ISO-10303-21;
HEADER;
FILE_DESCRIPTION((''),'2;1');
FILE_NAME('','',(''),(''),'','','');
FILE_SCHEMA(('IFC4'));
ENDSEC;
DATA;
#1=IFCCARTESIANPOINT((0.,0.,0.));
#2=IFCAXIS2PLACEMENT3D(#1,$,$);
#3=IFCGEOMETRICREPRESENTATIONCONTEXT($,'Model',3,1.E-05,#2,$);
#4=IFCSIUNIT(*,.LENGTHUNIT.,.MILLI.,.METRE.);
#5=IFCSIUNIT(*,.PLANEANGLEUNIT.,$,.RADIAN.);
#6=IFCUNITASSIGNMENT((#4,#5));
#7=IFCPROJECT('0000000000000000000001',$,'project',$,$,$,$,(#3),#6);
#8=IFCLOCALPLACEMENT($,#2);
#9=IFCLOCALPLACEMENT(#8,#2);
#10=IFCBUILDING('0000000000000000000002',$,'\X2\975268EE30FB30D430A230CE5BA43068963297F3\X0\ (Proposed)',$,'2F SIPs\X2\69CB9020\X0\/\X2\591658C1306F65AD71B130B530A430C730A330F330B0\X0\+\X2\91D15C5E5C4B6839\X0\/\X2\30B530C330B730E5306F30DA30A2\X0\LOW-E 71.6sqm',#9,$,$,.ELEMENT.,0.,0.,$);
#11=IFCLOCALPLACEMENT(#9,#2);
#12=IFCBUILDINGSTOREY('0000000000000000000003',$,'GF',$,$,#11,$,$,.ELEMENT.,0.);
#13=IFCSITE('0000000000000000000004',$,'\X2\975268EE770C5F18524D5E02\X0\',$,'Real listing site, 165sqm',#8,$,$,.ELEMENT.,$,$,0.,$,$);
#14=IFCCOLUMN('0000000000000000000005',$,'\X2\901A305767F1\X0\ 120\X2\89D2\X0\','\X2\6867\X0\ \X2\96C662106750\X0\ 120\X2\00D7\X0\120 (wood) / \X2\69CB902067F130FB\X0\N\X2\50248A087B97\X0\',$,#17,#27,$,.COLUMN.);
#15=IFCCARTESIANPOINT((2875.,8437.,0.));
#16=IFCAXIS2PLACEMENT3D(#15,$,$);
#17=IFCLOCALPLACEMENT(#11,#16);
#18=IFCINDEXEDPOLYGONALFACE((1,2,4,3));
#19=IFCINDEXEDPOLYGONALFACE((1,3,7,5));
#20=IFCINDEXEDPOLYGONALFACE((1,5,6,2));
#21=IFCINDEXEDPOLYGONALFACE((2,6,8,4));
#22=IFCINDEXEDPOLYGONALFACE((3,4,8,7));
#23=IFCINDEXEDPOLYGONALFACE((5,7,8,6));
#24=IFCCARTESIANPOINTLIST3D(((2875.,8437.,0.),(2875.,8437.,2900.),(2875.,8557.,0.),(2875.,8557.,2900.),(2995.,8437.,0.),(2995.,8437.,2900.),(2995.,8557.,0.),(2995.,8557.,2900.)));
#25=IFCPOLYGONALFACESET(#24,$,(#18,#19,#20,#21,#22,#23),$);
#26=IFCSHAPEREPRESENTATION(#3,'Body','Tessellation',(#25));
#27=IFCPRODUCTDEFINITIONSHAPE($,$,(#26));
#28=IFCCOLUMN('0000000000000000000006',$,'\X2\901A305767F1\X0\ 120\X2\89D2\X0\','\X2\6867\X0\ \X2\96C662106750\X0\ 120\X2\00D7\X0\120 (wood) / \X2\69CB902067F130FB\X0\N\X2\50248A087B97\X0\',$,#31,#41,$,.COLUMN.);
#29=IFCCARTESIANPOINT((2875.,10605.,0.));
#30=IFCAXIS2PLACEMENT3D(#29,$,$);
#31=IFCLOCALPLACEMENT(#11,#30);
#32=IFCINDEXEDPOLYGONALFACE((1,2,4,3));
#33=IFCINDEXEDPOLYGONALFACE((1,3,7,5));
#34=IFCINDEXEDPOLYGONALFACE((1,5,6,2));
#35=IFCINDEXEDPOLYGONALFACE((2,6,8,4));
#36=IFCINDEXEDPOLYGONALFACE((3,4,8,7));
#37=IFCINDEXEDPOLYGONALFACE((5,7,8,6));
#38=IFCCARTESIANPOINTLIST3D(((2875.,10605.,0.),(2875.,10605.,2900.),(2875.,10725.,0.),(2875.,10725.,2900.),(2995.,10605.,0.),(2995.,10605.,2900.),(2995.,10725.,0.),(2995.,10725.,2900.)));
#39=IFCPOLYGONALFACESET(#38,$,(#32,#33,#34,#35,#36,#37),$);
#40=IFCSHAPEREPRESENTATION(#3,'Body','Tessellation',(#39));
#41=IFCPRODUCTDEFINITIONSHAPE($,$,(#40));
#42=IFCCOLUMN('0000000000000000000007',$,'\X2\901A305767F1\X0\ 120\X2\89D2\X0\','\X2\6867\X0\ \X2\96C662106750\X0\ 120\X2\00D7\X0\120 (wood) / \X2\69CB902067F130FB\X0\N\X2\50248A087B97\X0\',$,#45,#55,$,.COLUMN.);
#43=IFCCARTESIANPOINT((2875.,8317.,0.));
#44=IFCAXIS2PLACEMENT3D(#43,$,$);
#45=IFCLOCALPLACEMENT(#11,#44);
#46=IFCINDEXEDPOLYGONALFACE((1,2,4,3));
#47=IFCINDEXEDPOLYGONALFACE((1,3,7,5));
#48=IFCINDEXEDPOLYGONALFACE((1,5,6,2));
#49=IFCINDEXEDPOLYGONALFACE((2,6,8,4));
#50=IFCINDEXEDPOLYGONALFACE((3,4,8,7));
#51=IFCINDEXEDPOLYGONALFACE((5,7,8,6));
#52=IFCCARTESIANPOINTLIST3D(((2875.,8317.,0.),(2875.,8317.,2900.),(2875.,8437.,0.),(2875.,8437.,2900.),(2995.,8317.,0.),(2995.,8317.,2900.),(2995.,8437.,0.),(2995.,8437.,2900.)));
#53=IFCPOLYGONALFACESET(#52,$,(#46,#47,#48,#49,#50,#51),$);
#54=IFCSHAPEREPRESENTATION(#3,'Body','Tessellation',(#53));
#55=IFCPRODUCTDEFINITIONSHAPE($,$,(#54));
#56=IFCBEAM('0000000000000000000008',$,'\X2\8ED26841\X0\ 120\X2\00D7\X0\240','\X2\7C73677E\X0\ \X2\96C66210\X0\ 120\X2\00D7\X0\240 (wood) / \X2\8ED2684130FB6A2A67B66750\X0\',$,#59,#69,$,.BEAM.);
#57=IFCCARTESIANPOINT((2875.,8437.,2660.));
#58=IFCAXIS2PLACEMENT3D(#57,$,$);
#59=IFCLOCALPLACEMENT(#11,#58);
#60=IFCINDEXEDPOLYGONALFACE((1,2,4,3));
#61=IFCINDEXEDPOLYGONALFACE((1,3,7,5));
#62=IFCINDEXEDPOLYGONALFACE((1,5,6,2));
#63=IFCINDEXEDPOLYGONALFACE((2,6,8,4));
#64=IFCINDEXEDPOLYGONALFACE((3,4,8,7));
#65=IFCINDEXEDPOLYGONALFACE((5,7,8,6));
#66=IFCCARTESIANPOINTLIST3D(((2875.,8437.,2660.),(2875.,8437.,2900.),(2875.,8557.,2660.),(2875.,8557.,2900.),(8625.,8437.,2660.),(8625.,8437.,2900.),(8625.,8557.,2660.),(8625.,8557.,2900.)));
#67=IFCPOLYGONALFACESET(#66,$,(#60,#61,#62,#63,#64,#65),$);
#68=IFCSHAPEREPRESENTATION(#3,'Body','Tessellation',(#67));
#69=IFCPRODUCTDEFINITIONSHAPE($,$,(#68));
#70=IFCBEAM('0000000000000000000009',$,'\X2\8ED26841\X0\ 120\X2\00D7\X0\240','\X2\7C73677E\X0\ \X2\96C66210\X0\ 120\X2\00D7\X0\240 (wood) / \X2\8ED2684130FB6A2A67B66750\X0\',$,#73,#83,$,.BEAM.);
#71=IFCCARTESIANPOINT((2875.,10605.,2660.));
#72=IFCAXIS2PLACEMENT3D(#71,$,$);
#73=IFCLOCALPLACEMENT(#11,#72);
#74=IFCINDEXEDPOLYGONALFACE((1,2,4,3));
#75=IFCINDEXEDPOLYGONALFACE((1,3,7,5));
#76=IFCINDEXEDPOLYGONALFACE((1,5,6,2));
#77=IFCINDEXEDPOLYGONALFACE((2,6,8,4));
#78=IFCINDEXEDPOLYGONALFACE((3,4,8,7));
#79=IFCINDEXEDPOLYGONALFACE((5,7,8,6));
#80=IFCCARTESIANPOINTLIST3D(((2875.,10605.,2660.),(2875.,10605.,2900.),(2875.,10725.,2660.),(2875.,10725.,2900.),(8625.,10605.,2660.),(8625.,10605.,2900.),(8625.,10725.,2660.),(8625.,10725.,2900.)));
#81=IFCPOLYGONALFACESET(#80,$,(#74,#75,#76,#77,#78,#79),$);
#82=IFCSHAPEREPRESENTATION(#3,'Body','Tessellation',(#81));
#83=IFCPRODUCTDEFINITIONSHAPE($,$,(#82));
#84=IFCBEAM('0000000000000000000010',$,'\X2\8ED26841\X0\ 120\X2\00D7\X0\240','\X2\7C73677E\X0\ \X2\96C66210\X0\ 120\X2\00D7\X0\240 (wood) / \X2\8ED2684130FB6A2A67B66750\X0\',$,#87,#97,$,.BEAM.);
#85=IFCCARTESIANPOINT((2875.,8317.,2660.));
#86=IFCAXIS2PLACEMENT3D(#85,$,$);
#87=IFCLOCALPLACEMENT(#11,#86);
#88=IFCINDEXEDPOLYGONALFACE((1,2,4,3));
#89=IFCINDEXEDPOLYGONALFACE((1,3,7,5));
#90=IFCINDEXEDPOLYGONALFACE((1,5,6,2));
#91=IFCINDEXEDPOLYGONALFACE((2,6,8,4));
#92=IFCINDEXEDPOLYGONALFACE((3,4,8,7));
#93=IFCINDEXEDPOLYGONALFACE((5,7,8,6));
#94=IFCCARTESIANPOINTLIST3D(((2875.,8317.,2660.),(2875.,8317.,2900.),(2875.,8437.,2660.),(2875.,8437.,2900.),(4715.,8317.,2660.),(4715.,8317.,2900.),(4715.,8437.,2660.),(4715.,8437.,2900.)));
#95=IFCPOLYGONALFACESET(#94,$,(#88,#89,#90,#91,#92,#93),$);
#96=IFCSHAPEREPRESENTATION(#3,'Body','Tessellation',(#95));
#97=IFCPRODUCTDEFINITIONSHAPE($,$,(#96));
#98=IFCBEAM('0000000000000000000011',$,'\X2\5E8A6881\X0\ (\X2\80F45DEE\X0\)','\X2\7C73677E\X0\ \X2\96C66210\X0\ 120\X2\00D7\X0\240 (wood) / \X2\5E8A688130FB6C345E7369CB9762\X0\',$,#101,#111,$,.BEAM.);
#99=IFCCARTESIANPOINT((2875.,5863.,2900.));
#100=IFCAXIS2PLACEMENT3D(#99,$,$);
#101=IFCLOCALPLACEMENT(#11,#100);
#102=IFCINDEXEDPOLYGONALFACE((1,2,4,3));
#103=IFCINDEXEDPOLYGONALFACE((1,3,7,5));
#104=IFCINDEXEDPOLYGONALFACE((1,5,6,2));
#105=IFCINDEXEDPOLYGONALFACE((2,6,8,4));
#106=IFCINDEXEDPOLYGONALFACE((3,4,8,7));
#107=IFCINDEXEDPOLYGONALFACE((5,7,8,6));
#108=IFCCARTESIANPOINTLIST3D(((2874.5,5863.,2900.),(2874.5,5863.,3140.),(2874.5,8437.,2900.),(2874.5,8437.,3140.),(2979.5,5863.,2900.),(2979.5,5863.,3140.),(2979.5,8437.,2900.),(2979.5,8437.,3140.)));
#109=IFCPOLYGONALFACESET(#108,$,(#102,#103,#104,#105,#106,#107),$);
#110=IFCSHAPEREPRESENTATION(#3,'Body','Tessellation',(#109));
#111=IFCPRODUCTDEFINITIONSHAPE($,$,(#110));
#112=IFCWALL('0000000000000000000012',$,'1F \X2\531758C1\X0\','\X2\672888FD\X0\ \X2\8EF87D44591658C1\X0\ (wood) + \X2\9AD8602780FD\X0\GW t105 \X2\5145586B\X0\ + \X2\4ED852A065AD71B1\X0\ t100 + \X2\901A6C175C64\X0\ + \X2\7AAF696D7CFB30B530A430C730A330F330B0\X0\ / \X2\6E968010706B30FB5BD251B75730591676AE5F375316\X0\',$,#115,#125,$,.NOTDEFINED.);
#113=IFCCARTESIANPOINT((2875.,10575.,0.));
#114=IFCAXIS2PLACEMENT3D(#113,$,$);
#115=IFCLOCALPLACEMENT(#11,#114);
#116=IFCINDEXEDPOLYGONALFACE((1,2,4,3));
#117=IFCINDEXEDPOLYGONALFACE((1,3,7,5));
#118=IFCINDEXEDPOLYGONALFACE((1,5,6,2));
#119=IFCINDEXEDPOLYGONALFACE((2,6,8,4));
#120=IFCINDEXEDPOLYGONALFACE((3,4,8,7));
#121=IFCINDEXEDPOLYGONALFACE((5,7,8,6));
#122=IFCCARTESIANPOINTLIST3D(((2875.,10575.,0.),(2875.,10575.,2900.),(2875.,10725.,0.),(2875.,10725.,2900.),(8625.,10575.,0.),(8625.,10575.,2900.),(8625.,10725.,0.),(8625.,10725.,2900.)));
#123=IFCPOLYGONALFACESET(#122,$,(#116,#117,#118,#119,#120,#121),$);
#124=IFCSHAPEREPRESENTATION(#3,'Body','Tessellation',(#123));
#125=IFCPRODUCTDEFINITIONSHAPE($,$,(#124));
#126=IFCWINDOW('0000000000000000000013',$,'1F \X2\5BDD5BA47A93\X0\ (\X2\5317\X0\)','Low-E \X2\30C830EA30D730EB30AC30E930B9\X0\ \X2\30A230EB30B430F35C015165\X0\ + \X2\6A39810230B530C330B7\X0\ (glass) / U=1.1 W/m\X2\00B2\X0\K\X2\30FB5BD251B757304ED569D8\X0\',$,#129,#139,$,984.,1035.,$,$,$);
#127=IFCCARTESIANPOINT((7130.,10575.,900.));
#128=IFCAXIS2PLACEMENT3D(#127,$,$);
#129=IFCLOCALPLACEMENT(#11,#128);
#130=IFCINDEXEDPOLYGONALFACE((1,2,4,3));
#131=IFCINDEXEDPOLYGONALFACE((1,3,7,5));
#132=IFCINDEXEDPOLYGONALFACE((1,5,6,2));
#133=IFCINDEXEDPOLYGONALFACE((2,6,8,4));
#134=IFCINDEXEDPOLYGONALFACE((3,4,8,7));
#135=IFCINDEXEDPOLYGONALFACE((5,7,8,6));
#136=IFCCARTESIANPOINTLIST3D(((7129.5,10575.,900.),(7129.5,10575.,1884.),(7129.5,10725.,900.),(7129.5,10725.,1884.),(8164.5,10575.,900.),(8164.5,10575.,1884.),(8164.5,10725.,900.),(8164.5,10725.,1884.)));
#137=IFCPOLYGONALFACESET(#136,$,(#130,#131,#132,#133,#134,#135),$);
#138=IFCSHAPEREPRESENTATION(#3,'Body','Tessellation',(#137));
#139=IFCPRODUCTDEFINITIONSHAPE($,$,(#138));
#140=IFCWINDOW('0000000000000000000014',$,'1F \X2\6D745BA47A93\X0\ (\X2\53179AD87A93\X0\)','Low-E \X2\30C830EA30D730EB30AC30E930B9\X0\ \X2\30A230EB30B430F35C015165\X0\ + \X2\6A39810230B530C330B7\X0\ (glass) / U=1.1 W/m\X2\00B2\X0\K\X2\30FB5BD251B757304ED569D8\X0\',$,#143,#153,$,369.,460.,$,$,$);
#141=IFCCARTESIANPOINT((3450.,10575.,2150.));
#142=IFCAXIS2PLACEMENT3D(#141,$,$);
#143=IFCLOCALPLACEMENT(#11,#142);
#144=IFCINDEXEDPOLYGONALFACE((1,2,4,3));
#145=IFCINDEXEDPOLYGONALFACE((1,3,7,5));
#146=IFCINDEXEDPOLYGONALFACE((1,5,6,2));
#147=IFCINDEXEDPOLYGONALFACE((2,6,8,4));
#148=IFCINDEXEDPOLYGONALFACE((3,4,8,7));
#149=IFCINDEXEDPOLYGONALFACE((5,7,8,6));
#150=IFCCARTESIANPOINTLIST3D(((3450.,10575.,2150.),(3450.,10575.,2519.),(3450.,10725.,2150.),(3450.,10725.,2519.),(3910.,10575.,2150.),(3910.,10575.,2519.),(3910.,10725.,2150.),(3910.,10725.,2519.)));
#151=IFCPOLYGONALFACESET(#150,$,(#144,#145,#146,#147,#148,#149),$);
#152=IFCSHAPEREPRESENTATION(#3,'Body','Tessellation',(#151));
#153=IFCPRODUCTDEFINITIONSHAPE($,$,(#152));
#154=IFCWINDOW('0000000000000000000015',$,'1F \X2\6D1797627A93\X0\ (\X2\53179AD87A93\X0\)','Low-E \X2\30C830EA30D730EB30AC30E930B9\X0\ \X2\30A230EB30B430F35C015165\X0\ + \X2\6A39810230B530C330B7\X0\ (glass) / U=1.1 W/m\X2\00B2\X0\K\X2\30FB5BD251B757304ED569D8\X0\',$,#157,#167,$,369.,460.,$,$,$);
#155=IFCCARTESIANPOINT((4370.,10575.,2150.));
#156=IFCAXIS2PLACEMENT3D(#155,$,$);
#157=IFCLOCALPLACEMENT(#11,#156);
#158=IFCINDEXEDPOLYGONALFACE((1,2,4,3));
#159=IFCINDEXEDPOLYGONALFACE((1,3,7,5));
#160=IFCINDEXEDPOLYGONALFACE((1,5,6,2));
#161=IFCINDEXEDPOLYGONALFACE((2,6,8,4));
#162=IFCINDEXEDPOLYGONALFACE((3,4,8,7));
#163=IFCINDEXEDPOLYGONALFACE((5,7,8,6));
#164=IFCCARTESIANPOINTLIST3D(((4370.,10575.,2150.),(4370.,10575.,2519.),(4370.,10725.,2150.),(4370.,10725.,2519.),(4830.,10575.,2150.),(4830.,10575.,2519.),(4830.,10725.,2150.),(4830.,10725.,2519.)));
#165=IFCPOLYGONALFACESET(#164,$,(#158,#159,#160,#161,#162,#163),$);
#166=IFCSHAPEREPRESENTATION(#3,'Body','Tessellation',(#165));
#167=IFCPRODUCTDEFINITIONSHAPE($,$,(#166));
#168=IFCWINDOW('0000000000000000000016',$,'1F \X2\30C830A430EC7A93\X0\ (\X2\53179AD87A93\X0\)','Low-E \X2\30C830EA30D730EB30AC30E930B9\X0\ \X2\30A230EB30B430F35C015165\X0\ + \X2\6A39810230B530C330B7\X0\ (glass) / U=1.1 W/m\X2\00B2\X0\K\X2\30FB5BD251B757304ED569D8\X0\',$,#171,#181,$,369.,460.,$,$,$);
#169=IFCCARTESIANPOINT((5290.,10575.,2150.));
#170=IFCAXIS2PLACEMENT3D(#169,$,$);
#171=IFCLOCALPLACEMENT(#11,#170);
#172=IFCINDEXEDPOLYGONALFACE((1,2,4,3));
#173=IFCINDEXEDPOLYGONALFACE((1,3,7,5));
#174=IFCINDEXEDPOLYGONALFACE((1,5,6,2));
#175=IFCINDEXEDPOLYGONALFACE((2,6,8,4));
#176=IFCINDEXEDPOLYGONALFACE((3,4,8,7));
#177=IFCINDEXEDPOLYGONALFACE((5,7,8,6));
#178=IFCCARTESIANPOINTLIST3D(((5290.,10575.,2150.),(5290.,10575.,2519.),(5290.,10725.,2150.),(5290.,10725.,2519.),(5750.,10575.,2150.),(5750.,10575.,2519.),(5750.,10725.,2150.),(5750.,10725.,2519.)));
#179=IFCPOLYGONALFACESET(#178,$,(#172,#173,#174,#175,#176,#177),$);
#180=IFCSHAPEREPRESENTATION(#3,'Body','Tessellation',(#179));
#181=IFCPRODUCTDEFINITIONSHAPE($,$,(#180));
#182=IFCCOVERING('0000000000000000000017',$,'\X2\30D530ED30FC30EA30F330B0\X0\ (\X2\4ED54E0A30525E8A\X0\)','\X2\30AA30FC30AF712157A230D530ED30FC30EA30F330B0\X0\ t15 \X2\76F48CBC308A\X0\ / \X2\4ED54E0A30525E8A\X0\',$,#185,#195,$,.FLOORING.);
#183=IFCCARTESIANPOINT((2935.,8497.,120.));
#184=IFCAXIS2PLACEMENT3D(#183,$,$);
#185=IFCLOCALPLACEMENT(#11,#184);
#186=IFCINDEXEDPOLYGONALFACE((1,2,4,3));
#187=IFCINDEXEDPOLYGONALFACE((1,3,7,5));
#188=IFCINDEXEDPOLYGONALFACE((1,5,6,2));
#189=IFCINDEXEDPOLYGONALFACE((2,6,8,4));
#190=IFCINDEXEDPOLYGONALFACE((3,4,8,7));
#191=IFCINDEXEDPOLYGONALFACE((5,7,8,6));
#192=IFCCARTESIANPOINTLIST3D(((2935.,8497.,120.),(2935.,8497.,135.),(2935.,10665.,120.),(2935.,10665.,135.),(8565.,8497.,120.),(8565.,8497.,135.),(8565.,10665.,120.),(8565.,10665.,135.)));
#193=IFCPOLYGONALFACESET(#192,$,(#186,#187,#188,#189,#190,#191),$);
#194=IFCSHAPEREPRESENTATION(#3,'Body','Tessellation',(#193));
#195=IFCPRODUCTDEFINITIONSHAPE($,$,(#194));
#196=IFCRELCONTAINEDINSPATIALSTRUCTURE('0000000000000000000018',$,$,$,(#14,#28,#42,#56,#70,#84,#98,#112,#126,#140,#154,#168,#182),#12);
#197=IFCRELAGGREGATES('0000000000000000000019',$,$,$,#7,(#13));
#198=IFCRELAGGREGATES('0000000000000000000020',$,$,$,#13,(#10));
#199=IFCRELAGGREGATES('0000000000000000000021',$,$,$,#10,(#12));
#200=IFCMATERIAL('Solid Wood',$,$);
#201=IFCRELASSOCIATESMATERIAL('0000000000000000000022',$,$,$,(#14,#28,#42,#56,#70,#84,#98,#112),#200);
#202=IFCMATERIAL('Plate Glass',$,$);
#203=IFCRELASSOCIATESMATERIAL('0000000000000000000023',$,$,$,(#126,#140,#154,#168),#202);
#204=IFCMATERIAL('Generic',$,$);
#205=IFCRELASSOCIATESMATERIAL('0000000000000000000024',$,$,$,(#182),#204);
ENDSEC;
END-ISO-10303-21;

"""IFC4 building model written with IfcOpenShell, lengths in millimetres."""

from ifc_helpers import new_model, si_unit, frame, frame_2d, origin, place, context, project, spatial, rectangle, extrude, material, element, fill, save


model = new_model("IFC4")

# Units and contexts
model_context = context("Model", 3, precision=1e-05, world=origin())
ifc_project = project(units=[si_unit("LENGTHUNIT", "METRE", prefix="MILLI"), si_unit("PLANEANGLEUNIT", "RADIAN")], contexts=[model_context])

# Site, building, storey
site_placement = place(None, origin())
site = spatial("IfcSite", under=ifc_project, at=site_placement, Name="青森県弘前市", ObjectType="Real listing site, 165sqm", CompositionType="ELEMENT", RefElevation=0.0)
building_placement = place(site_placement, origin())
building = spatial("IfcBuilding", under=site, at=building_placement, Name="青森・ピアノ室と防音 (Proposed)", ObjectType="2F SIPs構造/外壁は断熱サイディング+金属屋根/サッシュはペアLOW-E 71.6sqm", CompositionType="ELEMENT", ElevationOfRefHeight=0.0, ElevationOfTerrain=0.0)
storey_placement = place(building_placement, origin())
storey = spatial("IfcBuildingStorey", under=building, at=storey_placement, Name="GF", CompositionType="ELEMENT", Elevation=0.0)

# Columns
ifc_material_1 = material(Name="Solid Wood")
column_1_placement = place(storey_placement, frame((2875.0, 8437.0, 0.0)))
element("IfcColumn", 1, at=column_1_placement, inside=storey, material=ifc_material_1, Name="通し柱 120角", Description="桧 集成材 120×120 (wood) / 構造柱・N値計算", PredefinedType="COLUMN", context=model_context, shape_type="SweptSolid", body=[
    extrude(rectangle(XDim=120.0, YDim=120.0, at=frame_2d((60.0, 60.0))), frame((2875.0, 8437.0, 0.0)), (0.0, 0.0, 1.0), 2900.0),
])
column_2_placement = place(storey_placement, frame((2875.0, 10605.0, 0.0)))
element("IfcColumn", 2, at=column_2_placement, inside=storey, material=ifc_material_1, Name="通し柱 120角", Description="桧 集成材 120×120 (wood) / 構造柱・N値計算", PredefinedType="COLUMN", context=model_context, shape_type="SweptSolid", body=[
    extrude(rectangle(XDim=120.0, YDim=120.0, at=frame_2d((60.0, 60.0))), frame((2875.0, 10605.0, 0.0)), (0.0, 0.0, 1.0), 2900.0),
])
column_3_placement = place(storey_placement, frame((2875.0, 8317.0, 0.0)))
element("IfcColumn", 3, at=column_3_placement, inside=storey, material=ifc_material_1, Name="通し柱 120角", Description="桧 集成材 120×120 (wood) / 構造柱・N値計算", PredefinedType="COLUMN", context=model_context, shape_type="SweptSolid", body=[
    extrude(rectangle(XDim=120.0, YDim=120.0, at=frame_2d((60.0, 60.0))), frame((2875.0, 8317.0, 0.0)), (0.0, 0.0, 1.0), 2900.0),
])

# Beams
beam_1_placement = place(storey_placement, frame((2875.0, 8437.0, 2660.0)))
element("IfcBeam", 4, at=beam_1_placement, inside=storey, material=ifc_material_1, Name="軒桁 120×240", Description="米松 集成 120×240 (wood) / 軒桁・横架材", PredefinedType="BEAM", context=model_context, shape_type="SweptSolid", body=[
    extrude(rectangle(XDim=5750.0, YDim=120.0, at=frame_2d((2875.0, 60.0))), frame((2875.0, 8437.0, 2660.0)), (0.0, 0.0, 1.0), 240.0),
])
beam_2_placement = place(storey_placement, frame((2875.0, 10605.0, 2660.0)))
element("IfcBeam", 5, at=beam_2_placement, inside=storey, material=ifc_material_1, Name="軒桁 120×240", Description="米松 集成 120×240 (wood) / 軒桁・横架材", PredefinedType="BEAM", context=model_context, shape_type="SweptSolid", body=[
    extrude(rectangle(XDim=5750.0, YDim=120.0, at=frame_2d((2875.0, 60.0))), frame((2875.0, 10605.0, 2660.0)), (0.0, 0.0, 1.0), 240.0),
])
beam_3_placement = place(storey_placement, frame((2875.0, 8317.0, 2660.0)))
element("IfcBeam", 6, at=beam_3_placement, inside=storey, material=ifc_material_1, Name="軒桁 120×240", Description="米松 集成 120×240 (wood) / 軒桁・横架材", PredefinedType="BEAM", context=model_context, shape_type="SweptSolid", body=[
    extrude(rectangle(XDim=1840.0, YDim=120.0, at=frame_2d((920.0, 60.0))), frame((2875.0, 8317.0, 2660.0)), (0.0, 0.0, 1.0), 240.0),
])
beam_4_placement = place(storey_placement, frame((2875.0, 5863.0, 2900.0)))
element("IfcBeam", 7, at=beam_4_placement, inside=storey, material=ifc_material_1, Name="床梁 (胴差)", Description="米松 集成 120×240 (wood) / 床梁・水平構面", PredefinedType="BEAM", context=model_context, shape_type="SweptSolid", body=[
    extrude(rectangle(XDim=105.0, YDim=2574.0, at=frame_2d((52.0, 1287.0))), frame((2875.0, 5863.0, 2900.0)), (0.0, 0.0, 1.0), 240.0),
])

# Wall, openings, windows
wall_1_placement = place(storey_placement, frame((2875.0, 10575.0, 0.0)))
wall_1 = element("IfcWall", 8, at=wall_1_placement, inside=storey, material=ifc_material_1, Name="1F 北壁", Description="木製 軸組外壁 (wood) + 高性能GW t105 充填 + 付加断熱 t100 + 通気層 + 窯業系サイディング / 準耐火・寒冷地外皮強化", PredefinedType="NOTDEFINED", context=model_context, shape_type="SweptSolid", body=[
    extrude(rectangle(XDim=5750.0, YDim=150.0, at=frame_2d((2875.0, 75.0))), frame((2875.0, 10575.0, 0.0)), (0.0, 0.0, 1.0), 2900.0),
])
opening_1_placement = place(storey_placement, frame((7130.0, 10575.0, 900.0)))
opening_1 = element("IfcOpeningElement", 9, at=opening_1_placement, cuts=wall_1, PredefinedType="NOTDEFINED", context=model_context, shape_type="SweptSolid", body=[
    extrude(rectangle(XDim=1035.0, YDim=150.0, at=frame_2d((517.0, 75.0))), frame((7130.0, 10575.0, 900.0)), (0.0, 0.0, 1.0), 984.0),
])
opening_2_placement = place(storey_placement, frame((3450.0, 10575.0, 2150.0)))
opening_2 = element("IfcOpeningElement", 10, at=opening_2_placement, cuts=wall_1, PredefinedType="NOTDEFINED", context=model_context, shape_type="SweptSolid", body=[
    extrude(rectangle(XDim=460.0, YDim=150.0, at=frame_2d((230.0, 75.0))), frame((3450.0, 10575.0, 2150.0)), (0.0, 0.0, 1.0), 369.0),
])
opening_3_placement = place(storey_placement, frame((4370.0, 10575.0, 2150.0)))
opening_3 = element("IfcOpeningElement", 11, at=opening_3_placement, cuts=wall_1, PredefinedType="NOTDEFINED", context=model_context, shape_type="SweptSolid", body=[
    extrude(rectangle(XDim=460.0, YDim=150.0, at=frame_2d((230.0, 75.0))), frame((4370.0, 10575.0, 2150.0)), (0.0, 0.0, 1.0), 369.0),
])
opening_4_placement = place(storey_placement, frame((5290.0, 10575.0, 2150.0)))
opening_4 = element("IfcOpeningElement", 12, at=opening_4_placement, cuts=wall_1, PredefinedType="NOTDEFINED", context=model_context, shape_type="SweptSolid", body=[
    extrude(rectangle(XDim=460.0, YDim=150.0, at=frame_2d((230.0, 75.0))), frame((5290.0, 10575.0, 2150.0)), (0.0, 0.0, 1.0), 369.0),
])
ifc_material_2 = material(Name="Plate Glass")
window_1_placement = place(storey_placement, frame((7130.0, 10575.0, 900.0)))
window_1 = element("IfcWindow", 13, at=window_1_placement, inside=storey, material=ifc_material_2, Name="1F 寝室窓 (北)", Description="Low-E トリプルガラス アルゴン封入 + 樹脂サッシ (glass) / U=1.1 W/m²K・寒冷地仕様", OverallHeight=984.0, OverallWidth=1035.0, context=model_context, shape_type="SweptSolid", body=[
    extrude(rectangle(XDim=1035.0, YDim=150.0, at=frame_2d((517.0, 75.0))), frame((7130.0, 10575.0, 900.0)), (0.0, 0.0, 1.0), 984.0),
])
fill(opening_1, window_1)
window_2_placement = place(storey_placement, frame((3450.0, 10575.0, 2150.0)))
window_2 = element("IfcWindow", 14, at=window_2_placement, inside=storey, material=ifc_material_2, Name="1F 浴室窓 (北高窓)", Description="Low-E トリプルガラス アルゴン封入 + 樹脂サッシ (glass) / U=1.1 W/m²K・寒冷地仕様", OverallHeight=369.0, OverallWidth=460.0, context=model_context, shape_type="SweptSolid", body=[
    extrude(rectangle(XDim=460.0, YDim=150.0, at=frame_2d((230.0, 75.0))), frame((3450.0, 10575.0, 2150.0)), (0.0, 0.0, 1.0), 369.0),
])
fill(opening_2, window_2)
window_3_placement = place(storey_placement, frame((4370.0, 10575.0, 2150.0)))
window_3 = element("IfcWindow", 15, at=window_3_placement, inside=storey, material=ifc_material_2, Name="1F 洗面窓 (北高窓)", Description="Low-E トリプルガラス アルゴン封入 + 樹脂サッシ (glass) / U=1.1 W/m²K・寒冷地仕様", OverallHeight=369.0, OverallWidth=460.0, context=model_context, shape_type="SweptSolid", body=[
    extrude(rectangle(XDim=460.0, YDim=150.0, at=frame_2d((230.0, 75.0))), frame((4370.0, 10575.0, 2150.0)), (0.0, 0.0, 1.0), 369.0),
])
fill(opening_3, window_3)
window_4_placement = place(storey_placement, frame((5290.0, 10575.0, 2150.0)))
window_4 = element("IfcWindow", 16, at=window_4_placement, inside=storey, material=ifc_material_2, Name="1F トイレ窓 (北高窓)", Description="Low-E トリプルガラス アルゴン封入 + 樹脂サッシ (glass) / U=1.1 W/m²K・寒冷地仕様", OverallHeight=369.0, OverallWidth=460.0, context=model_context, shape_type="SweptSolid", body=[
    extrude(rectangle(XDim=460.0, YDim=150.0, at=frame_2d((230.0, 75.0))), frame((5290.0, 10575.0, 2150.0)), (0.0, 0.0, 1.0), 369.0),
])
fill(opening_4, window_4)

# Covering
ifc_material_3 = material(Name="Generic")
covering_1_placement = place(storey_placement, frame((2935.0, 8497.0, 120.0)))
element("IfcCovering", 17, at=covering_1_placement, inside=storey, material=ifc_material_3, Name="フローリング (仕上げ床)", Description="オーク無垢フローリング t15 直貼り / 仕上げ床", PredefinedType="FLOORING", context=model_context, shape_type="SweptSolid", body=[
    extrude(rectangle(XDim=5630.0, YDim=2168.0, at=frame_2d((2815.0, 1084.0))), frame((2935.0, 8497.0, 120.0)), (0.0, 0.0, 1.0), 15.0),
])

save(model, "model.ifc")
